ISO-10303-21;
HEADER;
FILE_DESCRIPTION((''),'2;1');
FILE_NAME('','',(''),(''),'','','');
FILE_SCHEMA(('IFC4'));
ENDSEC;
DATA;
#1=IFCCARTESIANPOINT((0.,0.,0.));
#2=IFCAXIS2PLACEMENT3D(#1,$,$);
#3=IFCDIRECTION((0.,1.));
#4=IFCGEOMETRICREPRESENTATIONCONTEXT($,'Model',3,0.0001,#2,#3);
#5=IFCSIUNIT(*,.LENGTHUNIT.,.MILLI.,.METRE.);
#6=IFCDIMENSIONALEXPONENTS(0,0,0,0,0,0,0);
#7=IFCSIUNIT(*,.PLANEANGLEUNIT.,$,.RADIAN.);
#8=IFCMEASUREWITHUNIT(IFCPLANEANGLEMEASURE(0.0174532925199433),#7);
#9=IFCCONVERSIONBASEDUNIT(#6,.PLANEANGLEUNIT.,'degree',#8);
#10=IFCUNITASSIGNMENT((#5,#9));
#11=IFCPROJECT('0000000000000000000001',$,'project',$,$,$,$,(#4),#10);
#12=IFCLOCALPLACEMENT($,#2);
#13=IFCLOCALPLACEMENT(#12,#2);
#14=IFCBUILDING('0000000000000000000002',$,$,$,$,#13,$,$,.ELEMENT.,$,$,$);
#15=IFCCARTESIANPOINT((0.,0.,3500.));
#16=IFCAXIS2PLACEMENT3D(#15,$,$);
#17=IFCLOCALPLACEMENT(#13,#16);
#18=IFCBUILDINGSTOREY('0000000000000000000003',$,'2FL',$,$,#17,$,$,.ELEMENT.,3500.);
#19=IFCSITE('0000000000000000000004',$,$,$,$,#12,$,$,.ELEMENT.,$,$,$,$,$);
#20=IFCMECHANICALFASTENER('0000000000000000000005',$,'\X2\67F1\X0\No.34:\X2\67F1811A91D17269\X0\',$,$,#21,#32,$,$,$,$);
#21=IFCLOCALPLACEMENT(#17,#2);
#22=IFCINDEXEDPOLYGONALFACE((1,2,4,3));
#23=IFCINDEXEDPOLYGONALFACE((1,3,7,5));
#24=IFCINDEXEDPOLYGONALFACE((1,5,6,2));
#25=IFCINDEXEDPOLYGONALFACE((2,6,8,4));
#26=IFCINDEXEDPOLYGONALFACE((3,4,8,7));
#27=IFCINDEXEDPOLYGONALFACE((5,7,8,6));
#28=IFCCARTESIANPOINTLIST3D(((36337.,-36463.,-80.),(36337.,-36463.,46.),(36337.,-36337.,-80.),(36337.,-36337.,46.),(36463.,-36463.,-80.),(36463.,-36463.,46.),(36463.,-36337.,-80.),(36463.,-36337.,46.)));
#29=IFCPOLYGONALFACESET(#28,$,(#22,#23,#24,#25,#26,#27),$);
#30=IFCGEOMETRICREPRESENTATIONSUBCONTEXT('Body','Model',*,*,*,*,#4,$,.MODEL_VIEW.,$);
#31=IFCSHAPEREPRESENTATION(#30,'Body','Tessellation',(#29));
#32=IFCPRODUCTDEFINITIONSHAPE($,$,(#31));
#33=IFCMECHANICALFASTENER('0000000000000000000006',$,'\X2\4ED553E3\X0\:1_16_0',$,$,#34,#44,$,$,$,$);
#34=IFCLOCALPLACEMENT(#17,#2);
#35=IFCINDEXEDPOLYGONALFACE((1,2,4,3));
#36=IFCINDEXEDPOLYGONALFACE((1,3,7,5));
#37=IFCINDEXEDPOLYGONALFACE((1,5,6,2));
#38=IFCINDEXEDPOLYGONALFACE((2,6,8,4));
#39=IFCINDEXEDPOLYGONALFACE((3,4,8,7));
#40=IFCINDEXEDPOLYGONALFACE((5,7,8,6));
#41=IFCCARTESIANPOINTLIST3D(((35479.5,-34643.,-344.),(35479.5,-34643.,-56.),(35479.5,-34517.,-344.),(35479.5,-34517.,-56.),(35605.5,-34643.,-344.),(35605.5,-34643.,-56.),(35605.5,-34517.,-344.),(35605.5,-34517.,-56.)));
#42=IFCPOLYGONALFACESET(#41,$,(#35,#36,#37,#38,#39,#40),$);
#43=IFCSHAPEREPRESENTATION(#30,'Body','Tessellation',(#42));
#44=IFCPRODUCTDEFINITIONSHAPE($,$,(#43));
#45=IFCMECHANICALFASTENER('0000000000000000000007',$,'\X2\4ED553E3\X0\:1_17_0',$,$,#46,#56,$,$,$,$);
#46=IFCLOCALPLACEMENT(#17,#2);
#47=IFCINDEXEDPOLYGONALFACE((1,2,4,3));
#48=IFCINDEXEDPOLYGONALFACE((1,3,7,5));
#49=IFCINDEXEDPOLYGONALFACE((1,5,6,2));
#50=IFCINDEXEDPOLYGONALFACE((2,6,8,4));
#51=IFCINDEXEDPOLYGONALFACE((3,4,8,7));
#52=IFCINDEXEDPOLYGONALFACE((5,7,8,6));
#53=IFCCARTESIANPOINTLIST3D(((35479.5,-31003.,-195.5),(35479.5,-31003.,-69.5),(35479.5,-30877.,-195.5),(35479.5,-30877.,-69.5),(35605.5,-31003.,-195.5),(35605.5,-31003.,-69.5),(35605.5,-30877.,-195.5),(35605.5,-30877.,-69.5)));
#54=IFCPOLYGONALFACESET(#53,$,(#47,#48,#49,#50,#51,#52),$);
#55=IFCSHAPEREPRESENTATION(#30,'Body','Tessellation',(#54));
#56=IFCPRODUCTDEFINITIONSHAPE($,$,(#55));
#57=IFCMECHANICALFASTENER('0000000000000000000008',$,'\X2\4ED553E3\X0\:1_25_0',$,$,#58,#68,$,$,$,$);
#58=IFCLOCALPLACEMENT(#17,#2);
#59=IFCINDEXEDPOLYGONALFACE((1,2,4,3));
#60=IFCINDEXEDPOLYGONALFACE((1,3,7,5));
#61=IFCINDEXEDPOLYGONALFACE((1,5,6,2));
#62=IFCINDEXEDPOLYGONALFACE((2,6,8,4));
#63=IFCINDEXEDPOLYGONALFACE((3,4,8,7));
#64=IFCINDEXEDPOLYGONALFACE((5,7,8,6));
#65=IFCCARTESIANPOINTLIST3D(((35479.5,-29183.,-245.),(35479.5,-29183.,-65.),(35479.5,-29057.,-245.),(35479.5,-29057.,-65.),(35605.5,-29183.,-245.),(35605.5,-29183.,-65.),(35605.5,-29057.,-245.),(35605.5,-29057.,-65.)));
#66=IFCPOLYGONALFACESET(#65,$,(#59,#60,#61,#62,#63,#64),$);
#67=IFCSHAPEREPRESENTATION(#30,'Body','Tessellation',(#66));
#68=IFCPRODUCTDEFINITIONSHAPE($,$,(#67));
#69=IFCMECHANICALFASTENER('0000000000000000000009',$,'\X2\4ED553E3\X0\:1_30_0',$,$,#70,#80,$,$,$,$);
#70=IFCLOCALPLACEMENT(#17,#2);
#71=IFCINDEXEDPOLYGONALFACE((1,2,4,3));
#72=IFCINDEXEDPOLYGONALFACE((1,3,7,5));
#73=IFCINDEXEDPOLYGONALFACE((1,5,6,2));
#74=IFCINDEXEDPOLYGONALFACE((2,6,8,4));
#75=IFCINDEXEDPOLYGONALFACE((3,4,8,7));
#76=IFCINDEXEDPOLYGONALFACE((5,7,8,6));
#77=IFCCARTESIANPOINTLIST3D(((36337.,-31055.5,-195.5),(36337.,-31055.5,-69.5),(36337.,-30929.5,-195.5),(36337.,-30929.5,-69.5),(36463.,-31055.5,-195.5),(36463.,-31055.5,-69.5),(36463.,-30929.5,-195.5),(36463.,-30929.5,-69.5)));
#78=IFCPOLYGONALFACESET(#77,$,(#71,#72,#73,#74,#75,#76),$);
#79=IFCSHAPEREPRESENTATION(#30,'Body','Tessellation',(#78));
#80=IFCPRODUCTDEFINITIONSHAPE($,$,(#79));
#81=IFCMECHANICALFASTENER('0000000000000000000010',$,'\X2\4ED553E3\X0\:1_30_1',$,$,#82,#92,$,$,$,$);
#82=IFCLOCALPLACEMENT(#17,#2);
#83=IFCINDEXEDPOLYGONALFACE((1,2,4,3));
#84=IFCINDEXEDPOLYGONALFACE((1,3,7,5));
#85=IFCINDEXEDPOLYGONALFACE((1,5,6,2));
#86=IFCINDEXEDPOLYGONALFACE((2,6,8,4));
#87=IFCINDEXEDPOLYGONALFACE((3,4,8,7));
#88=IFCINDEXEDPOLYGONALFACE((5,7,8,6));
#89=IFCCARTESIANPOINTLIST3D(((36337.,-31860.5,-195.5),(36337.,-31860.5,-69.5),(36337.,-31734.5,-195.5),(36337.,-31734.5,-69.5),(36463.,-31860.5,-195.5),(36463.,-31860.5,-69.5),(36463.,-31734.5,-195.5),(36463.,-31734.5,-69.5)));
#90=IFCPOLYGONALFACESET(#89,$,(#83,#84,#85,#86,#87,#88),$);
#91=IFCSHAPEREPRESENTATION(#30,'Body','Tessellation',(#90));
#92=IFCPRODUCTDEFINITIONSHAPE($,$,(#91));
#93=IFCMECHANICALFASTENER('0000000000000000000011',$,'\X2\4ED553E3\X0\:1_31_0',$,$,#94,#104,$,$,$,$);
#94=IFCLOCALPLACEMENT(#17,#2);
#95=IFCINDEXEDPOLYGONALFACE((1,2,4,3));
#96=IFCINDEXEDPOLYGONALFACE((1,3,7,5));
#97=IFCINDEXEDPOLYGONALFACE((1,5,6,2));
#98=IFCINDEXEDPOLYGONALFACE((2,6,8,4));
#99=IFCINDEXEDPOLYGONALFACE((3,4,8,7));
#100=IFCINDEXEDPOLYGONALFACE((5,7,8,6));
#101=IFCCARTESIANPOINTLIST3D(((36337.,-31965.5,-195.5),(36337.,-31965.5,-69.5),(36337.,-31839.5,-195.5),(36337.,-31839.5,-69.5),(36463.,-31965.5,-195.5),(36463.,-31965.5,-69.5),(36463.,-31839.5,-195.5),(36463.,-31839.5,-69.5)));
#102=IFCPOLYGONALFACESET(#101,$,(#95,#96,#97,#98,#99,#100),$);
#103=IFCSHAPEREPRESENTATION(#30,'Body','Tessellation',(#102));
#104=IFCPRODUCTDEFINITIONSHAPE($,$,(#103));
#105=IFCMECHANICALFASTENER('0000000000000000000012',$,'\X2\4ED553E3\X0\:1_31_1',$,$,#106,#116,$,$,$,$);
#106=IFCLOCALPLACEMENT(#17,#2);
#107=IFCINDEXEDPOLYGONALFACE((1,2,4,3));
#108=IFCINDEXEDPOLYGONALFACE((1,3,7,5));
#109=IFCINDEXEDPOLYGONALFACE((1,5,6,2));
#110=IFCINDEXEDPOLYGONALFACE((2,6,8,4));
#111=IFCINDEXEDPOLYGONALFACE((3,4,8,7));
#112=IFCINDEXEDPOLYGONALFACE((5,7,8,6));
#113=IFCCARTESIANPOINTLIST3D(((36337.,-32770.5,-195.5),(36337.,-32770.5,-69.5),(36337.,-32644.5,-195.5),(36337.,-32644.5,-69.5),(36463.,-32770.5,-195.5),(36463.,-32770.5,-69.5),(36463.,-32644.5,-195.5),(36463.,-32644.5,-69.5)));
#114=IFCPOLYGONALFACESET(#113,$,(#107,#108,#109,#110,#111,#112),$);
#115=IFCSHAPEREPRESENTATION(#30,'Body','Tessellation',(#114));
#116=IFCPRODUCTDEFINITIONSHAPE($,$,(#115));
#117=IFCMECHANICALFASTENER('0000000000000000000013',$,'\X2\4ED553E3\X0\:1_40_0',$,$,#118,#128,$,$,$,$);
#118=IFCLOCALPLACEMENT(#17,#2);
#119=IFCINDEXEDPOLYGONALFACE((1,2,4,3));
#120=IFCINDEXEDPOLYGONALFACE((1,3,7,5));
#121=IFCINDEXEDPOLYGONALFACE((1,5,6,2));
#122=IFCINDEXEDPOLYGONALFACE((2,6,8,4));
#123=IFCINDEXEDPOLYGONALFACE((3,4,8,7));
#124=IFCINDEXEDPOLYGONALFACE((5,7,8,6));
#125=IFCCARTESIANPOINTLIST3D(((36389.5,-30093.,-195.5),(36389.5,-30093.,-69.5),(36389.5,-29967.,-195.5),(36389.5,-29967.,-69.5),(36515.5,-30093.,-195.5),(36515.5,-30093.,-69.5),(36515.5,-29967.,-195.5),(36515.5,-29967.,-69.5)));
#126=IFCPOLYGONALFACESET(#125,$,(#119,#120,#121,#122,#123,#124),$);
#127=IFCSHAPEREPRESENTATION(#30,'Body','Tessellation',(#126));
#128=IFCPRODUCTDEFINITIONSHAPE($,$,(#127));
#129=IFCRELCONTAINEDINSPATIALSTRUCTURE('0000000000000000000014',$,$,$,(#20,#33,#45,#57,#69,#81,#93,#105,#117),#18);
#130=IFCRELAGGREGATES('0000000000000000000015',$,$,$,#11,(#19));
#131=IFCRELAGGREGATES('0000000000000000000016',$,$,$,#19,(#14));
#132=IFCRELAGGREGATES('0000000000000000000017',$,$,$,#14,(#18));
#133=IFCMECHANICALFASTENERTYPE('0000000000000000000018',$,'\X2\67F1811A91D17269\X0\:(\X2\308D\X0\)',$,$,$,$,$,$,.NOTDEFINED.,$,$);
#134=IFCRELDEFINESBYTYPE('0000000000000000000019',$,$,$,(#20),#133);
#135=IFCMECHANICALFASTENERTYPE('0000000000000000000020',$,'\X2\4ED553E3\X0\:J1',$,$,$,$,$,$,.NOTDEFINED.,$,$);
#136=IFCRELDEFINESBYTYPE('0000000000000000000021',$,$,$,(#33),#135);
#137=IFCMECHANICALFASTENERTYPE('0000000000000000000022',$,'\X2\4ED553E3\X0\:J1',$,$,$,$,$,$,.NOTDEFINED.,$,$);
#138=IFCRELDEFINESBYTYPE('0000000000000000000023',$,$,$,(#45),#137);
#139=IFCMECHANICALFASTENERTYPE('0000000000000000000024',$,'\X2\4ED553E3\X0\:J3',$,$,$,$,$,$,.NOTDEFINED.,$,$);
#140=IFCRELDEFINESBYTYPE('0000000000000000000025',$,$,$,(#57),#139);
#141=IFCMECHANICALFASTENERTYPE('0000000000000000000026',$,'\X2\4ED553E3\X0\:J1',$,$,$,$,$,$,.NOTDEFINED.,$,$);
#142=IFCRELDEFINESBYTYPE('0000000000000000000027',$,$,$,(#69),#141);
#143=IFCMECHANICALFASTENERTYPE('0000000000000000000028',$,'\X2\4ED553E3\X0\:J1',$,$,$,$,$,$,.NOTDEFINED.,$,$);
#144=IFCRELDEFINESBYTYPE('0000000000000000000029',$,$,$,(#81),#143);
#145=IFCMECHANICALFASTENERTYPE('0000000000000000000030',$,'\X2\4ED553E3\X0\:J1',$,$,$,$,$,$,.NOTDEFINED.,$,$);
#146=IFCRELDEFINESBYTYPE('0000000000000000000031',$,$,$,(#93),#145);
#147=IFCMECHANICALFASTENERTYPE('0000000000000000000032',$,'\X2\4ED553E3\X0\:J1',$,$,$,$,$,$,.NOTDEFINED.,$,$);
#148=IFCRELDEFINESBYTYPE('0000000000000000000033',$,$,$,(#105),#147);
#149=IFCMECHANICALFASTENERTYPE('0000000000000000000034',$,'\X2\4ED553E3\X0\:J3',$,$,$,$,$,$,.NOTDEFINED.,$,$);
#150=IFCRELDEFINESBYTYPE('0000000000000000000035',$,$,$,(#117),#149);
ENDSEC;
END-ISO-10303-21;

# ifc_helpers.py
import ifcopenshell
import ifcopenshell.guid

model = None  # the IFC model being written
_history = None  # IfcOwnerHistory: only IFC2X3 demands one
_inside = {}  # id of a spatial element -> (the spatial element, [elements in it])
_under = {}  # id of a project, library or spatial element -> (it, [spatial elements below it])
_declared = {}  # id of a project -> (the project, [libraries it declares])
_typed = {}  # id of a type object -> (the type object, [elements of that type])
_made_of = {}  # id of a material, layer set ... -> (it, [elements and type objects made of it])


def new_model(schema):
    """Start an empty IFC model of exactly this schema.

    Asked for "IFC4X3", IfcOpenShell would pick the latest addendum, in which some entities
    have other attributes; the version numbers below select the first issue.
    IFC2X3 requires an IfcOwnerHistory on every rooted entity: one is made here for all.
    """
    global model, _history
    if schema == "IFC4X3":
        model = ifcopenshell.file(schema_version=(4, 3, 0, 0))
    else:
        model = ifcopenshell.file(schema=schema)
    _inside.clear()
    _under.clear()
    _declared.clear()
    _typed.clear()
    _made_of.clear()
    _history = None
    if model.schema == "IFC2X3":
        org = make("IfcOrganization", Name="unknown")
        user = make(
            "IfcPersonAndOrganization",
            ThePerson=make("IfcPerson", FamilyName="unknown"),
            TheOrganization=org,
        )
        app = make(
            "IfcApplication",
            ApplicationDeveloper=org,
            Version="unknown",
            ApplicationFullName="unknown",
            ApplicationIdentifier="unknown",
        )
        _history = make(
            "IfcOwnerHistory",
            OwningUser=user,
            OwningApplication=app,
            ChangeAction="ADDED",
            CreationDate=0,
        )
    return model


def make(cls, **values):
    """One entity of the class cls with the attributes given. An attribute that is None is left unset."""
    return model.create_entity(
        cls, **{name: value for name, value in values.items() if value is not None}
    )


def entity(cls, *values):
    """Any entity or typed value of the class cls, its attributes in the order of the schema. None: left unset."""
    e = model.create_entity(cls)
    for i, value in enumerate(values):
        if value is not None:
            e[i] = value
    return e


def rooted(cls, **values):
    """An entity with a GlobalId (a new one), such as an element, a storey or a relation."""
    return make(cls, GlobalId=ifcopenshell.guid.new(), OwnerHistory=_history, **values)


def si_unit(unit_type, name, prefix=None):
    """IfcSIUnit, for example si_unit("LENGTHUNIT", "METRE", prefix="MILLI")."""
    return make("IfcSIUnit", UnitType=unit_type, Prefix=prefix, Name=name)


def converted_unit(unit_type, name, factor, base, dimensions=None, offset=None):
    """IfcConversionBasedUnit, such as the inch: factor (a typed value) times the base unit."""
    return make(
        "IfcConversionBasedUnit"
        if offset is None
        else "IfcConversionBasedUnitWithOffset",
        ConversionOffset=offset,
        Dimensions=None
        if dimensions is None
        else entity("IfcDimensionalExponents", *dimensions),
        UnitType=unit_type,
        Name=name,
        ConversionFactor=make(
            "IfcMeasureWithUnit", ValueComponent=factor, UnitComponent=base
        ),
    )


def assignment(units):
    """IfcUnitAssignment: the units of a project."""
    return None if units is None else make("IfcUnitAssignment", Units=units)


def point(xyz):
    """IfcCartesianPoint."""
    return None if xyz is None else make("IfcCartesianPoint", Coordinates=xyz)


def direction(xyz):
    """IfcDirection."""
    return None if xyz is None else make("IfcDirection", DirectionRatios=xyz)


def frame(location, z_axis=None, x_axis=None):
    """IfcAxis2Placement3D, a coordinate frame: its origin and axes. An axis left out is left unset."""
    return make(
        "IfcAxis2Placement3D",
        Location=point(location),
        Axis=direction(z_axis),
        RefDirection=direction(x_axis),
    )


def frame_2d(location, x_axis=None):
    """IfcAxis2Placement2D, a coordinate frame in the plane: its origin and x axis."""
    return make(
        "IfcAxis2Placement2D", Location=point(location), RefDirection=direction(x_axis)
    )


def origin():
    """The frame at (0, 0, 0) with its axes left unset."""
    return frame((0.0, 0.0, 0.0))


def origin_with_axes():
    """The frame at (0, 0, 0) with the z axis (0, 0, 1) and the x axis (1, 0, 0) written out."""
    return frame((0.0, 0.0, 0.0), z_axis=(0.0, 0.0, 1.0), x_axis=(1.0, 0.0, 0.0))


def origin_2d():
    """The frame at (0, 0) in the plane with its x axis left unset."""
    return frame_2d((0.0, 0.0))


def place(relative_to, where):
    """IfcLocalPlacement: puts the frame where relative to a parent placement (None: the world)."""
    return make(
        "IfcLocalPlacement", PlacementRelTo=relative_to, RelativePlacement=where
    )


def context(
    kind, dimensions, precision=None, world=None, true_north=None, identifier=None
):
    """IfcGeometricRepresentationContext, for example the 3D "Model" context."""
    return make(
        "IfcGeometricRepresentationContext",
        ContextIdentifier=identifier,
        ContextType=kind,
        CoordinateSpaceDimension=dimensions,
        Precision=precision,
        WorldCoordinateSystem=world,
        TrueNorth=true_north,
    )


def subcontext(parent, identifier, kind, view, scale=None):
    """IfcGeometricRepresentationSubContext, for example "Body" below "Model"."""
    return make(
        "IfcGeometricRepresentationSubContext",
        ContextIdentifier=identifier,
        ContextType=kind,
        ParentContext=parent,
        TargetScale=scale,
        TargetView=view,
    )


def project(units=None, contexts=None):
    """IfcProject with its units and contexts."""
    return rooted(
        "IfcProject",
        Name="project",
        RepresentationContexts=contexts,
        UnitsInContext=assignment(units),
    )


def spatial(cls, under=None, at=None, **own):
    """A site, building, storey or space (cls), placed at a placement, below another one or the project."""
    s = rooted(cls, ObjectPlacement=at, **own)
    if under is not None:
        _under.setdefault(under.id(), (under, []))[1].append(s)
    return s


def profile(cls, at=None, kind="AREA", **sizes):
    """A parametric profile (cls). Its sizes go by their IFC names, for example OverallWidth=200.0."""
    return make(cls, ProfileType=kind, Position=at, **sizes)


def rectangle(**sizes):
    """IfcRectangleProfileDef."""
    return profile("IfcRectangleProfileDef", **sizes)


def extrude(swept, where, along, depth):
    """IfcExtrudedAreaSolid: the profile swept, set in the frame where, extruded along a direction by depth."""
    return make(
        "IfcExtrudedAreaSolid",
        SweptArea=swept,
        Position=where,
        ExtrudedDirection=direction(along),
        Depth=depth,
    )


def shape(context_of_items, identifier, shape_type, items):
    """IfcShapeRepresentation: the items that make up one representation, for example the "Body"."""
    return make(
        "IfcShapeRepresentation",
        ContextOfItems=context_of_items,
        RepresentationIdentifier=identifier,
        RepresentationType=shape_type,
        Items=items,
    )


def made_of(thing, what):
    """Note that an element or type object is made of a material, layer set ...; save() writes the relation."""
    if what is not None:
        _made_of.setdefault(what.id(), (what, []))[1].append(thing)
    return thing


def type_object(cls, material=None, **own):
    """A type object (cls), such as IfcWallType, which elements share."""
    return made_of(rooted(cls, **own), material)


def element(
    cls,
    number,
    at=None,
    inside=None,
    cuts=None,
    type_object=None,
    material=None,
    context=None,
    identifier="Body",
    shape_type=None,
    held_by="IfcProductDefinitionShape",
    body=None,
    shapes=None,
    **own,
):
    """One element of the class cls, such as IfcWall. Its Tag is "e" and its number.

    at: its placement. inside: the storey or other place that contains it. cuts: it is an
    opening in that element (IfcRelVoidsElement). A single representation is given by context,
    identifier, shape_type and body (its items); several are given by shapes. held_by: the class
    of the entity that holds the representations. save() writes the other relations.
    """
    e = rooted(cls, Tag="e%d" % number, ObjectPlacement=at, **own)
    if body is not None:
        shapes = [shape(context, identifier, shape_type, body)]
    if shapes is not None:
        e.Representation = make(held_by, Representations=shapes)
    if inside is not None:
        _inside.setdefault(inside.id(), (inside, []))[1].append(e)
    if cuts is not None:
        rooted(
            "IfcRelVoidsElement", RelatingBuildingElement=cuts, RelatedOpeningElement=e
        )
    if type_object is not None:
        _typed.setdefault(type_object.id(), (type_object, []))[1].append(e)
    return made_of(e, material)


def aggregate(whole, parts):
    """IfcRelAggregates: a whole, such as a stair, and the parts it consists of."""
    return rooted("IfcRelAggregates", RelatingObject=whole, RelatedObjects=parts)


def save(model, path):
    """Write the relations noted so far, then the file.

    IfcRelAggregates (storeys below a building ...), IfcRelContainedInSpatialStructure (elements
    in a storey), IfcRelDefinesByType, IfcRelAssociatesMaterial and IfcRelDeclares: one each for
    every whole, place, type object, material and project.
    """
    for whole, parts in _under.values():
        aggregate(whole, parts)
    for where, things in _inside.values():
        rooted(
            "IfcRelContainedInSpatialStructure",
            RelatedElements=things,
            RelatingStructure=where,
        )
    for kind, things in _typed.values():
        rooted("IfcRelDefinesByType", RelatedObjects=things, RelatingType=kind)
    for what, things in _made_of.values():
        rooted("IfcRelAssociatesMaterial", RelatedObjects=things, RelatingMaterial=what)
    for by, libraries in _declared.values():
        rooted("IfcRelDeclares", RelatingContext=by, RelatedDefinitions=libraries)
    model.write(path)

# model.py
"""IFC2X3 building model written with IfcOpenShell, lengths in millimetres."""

from ifc_helpers import new_model, entity, si_unit, converted_unit, direction, frame, origin, origin_with_axes, origin_2d, place, context, subcontext, project, spatial, rectangle, extrude, type_object, element, save


model = new_model("IFC2X3")

# Units and contexts
model_context = context("Model", 3, precision=0.0001, world=origin(), true_north=direction((0.0, 1.0)))
body_context = subcontext(model_context, "Body", "Model", "MODEL_VIEW")
ifc_project = project(units=[si_unit("LENGTHUNIT", "METRE", prefix="MILLI"), converted_unit("PLANEANGLEUNIT", "degree", entity("IfcPlaneAngleMeasure", 0.0174532925199433), si_unit("PLANEANGLEUNIT", "RADIAN"), dimensions=[0, 0, 0, 0, 0, 0, 0])], contexts=[model_context])

# Site, building, storey
site_placement = place(None, origin())
site = spatial("IfcSite", under=ifc_project, at=site_placement, CompositionType="ELEMENT")
building_placement = place(site_placement, origin())
building = spatial("IfcBuilding", under=site, at=building_placement, CompositionType="ELEMENT")
storey_placement = place(building_placement, frame((0.0, 0.0, 3500.0)))
storey = spatial("IfcBuildingStorey", under=building, at=storey_placement, Name="2FL", CompositionType="ELEMENT", Elevation=3500.0)

# Mechanical fasteners
mechanical_fastener_type_1 = type_object("IfcMechanicalFastenerType", Name="柱脚金物:(ろ)")
mechanical_fastener_1_placement = place(storey_placement, frame((36400.0, -36400.0, -80.0)))
element("IfcMechanicalFastener", 1, at=mechanical_fastener_1_placement, inside=storey, type_object=mechanical_fastener_type_1, Name="柱No.34:柱脚金物", context=body_context, shape_type="SweptSolid", body=[
    extrude(rectangle(XDim=126.0, YDim=126.0, at=origin_2d()), origin_with_axes(), (0.0, 0.0, 1.0), 126.0),
])
mechanical_fastener_type_2 = type_object("IfcMechanicalFastenerType", Name="仕口:J1")
mechanical_fastener_2_placement = place(storey_placement, frame((35542.5, -34580.0, -344.0)))
element("IfcMechanicalFastener", 2, at=mechanical_fastener_2_placement, inside=storey, type_object=mechanical_fastener_type_2, Name="仕口:1_16_0", context=body_context, shape_type="SweptSolid", body=[
    extrude(rectangle(XDim=126.0, YDim=126.0, at=origin_2d()), origin_with_axes(), (0.0, 0.0, 1.0), 288.0),
])
mechanical_fastener_type_3 = type_object("IfcMechanicalFastenerType", Name="仕口:J1")
mechanical_fastener_3_placement = place(storey_placement, frame((35542.5, -30940.0, -195.5)))
element("IfcMechanicalFastener", 3, at=mechanical_fastener_3_placement, inside=storey, type_object=mechanical_fastener_type_3, Name="仕口:1_17_0", context=body_context, shape_type="SweptSolid", body=[
    extrude(rectangle(XDim=126.0, YDim=126.0, at=origin_2d()), origin_with_axes(), (0.0, 0.0, 1.0), 126.0),
])
mechanical_fastener_type_4 = type_object("IfcMechanicalFastenerType", Name="仕口:J3")
mechanical_fastener_4_placement = place(storey_placement, frame((35542.5, -29120.0, -245.0)))
element("IfcMechanicalFastener", 4, at=mechanical_fastener_4_placement, inside=storey, type_object=mechanical_fastener_type_4, Name="仕口:1_25_0", context=body_context, shape_type="SweptSolid", body=[
    extrude(rectangle(XDim=126.0, YDim=126.0, at=origin_2d()), origin_with_axes(), (0.0, 0.0, 1.0), 180.0),
])
mechanical_fastener_type_5 = type_object("IfcMechanicalFastenerType", Name="仕口:J1")
mechanical_fastener_5_placement = place(storey_placement, frame((36400.0, -30992.5, -195.5)))
element("IfcMechanicalFastener", 5, at=mechanical_fastener_5_placement, inside=storey, type_object=mechanical_fastener_type_5, Name="仕口:1_30_0", context=body_context, shape_type="SweptSolid", body=[
    extrude(rectangle(XDim=126.0, YDim=126.0, at=origin_2d()), origin_with_axes(), (0.0, 0.0, 1.0), 126.0),
])
mechanical_fastener_type_6 = type_object("IfcMechanicalFastenerType", Name="仕口:J1")
mechanical_fastener_6_placement = place(storey_placement, frame((36400.0, -31797.5, -195.5)))
element("IfcMechanicalFastener", 6, at=mechanical_fastener_6_placement, inside=storey, type_object=mechanical_fastener_type_6, Name="仕口:1_30_1", context=body_context, shape_type="SweptSolid", body=[
    extrude(rectangle(XDim=126.0, YDim=126.0, at=origin_2d()), origin_with_axes(), (0.0, 0.0, 1.0), 126.0),
])
mechanical_fastener_type_7 = type_object("IfcMechanicalFastenerType", Name="仕口:J1")
mechanical_fastener_7_placement = place(storey_placement, frame((36400.0, -31902.5, -195.5)))
element("IfcMechanicalFastener", 7, at=mechanical_fastener_7_placement, inside=storey, type_object=mechanical_fastener_type_7, Name="仕口:1_31_0", context=body_context, shape_type="SweptSolid", body=[
    extrude(rectangle(XDim=126.0, YDim=126.0, at=origin_2d()), origin_with_axes(), (0.0, 0.0, 1.0), 126.0),
])
mechanical_fastener_type_8 = type_object("IfcMechanicalFastenerType", Name="仕口:J1")
mechanical_fastener_8_placement = place(storey_placement, frame((36400.0, -32707.5, -195.5)))
element("IfcMechanicalFastener", 8, at=mechanical_fastener_8_placement, inside=storey, type_object=mechanical_fastener_type_8, Name="仕口:1_31_1", context=body_context, shape_type="SweptSolid", body=[
    extrude(rectangle(XDim=126.0, YDim=126.0, at=origin_2d()), origin_with_axes(), (0.0, 0.0, 1.0), 126.0),
])
mechanical_fastener_type_9 = type_object("IfcMechanicalFastenerType", Name="仕口:J3")
mechanical_fastener_9_placement = place(storey_placement, frame((36452.5, -30030.0, -195.5)))
element("IfcMechanicalFastener", 9, at=mechanical_fastener_9_placement, inside=storey, type_object=mechanical_fastener_type_9, Name="仕口:1_40_0", context=body_context, shape_type="SweptSolid", body=[
    extrude(rectangle(XDim=126.0, YDim=126.0, at=origin_2d()), origin_with_axes(), (0.0, 0.0, 1.0), 126.0),
])

save(model, "model.ifc")
